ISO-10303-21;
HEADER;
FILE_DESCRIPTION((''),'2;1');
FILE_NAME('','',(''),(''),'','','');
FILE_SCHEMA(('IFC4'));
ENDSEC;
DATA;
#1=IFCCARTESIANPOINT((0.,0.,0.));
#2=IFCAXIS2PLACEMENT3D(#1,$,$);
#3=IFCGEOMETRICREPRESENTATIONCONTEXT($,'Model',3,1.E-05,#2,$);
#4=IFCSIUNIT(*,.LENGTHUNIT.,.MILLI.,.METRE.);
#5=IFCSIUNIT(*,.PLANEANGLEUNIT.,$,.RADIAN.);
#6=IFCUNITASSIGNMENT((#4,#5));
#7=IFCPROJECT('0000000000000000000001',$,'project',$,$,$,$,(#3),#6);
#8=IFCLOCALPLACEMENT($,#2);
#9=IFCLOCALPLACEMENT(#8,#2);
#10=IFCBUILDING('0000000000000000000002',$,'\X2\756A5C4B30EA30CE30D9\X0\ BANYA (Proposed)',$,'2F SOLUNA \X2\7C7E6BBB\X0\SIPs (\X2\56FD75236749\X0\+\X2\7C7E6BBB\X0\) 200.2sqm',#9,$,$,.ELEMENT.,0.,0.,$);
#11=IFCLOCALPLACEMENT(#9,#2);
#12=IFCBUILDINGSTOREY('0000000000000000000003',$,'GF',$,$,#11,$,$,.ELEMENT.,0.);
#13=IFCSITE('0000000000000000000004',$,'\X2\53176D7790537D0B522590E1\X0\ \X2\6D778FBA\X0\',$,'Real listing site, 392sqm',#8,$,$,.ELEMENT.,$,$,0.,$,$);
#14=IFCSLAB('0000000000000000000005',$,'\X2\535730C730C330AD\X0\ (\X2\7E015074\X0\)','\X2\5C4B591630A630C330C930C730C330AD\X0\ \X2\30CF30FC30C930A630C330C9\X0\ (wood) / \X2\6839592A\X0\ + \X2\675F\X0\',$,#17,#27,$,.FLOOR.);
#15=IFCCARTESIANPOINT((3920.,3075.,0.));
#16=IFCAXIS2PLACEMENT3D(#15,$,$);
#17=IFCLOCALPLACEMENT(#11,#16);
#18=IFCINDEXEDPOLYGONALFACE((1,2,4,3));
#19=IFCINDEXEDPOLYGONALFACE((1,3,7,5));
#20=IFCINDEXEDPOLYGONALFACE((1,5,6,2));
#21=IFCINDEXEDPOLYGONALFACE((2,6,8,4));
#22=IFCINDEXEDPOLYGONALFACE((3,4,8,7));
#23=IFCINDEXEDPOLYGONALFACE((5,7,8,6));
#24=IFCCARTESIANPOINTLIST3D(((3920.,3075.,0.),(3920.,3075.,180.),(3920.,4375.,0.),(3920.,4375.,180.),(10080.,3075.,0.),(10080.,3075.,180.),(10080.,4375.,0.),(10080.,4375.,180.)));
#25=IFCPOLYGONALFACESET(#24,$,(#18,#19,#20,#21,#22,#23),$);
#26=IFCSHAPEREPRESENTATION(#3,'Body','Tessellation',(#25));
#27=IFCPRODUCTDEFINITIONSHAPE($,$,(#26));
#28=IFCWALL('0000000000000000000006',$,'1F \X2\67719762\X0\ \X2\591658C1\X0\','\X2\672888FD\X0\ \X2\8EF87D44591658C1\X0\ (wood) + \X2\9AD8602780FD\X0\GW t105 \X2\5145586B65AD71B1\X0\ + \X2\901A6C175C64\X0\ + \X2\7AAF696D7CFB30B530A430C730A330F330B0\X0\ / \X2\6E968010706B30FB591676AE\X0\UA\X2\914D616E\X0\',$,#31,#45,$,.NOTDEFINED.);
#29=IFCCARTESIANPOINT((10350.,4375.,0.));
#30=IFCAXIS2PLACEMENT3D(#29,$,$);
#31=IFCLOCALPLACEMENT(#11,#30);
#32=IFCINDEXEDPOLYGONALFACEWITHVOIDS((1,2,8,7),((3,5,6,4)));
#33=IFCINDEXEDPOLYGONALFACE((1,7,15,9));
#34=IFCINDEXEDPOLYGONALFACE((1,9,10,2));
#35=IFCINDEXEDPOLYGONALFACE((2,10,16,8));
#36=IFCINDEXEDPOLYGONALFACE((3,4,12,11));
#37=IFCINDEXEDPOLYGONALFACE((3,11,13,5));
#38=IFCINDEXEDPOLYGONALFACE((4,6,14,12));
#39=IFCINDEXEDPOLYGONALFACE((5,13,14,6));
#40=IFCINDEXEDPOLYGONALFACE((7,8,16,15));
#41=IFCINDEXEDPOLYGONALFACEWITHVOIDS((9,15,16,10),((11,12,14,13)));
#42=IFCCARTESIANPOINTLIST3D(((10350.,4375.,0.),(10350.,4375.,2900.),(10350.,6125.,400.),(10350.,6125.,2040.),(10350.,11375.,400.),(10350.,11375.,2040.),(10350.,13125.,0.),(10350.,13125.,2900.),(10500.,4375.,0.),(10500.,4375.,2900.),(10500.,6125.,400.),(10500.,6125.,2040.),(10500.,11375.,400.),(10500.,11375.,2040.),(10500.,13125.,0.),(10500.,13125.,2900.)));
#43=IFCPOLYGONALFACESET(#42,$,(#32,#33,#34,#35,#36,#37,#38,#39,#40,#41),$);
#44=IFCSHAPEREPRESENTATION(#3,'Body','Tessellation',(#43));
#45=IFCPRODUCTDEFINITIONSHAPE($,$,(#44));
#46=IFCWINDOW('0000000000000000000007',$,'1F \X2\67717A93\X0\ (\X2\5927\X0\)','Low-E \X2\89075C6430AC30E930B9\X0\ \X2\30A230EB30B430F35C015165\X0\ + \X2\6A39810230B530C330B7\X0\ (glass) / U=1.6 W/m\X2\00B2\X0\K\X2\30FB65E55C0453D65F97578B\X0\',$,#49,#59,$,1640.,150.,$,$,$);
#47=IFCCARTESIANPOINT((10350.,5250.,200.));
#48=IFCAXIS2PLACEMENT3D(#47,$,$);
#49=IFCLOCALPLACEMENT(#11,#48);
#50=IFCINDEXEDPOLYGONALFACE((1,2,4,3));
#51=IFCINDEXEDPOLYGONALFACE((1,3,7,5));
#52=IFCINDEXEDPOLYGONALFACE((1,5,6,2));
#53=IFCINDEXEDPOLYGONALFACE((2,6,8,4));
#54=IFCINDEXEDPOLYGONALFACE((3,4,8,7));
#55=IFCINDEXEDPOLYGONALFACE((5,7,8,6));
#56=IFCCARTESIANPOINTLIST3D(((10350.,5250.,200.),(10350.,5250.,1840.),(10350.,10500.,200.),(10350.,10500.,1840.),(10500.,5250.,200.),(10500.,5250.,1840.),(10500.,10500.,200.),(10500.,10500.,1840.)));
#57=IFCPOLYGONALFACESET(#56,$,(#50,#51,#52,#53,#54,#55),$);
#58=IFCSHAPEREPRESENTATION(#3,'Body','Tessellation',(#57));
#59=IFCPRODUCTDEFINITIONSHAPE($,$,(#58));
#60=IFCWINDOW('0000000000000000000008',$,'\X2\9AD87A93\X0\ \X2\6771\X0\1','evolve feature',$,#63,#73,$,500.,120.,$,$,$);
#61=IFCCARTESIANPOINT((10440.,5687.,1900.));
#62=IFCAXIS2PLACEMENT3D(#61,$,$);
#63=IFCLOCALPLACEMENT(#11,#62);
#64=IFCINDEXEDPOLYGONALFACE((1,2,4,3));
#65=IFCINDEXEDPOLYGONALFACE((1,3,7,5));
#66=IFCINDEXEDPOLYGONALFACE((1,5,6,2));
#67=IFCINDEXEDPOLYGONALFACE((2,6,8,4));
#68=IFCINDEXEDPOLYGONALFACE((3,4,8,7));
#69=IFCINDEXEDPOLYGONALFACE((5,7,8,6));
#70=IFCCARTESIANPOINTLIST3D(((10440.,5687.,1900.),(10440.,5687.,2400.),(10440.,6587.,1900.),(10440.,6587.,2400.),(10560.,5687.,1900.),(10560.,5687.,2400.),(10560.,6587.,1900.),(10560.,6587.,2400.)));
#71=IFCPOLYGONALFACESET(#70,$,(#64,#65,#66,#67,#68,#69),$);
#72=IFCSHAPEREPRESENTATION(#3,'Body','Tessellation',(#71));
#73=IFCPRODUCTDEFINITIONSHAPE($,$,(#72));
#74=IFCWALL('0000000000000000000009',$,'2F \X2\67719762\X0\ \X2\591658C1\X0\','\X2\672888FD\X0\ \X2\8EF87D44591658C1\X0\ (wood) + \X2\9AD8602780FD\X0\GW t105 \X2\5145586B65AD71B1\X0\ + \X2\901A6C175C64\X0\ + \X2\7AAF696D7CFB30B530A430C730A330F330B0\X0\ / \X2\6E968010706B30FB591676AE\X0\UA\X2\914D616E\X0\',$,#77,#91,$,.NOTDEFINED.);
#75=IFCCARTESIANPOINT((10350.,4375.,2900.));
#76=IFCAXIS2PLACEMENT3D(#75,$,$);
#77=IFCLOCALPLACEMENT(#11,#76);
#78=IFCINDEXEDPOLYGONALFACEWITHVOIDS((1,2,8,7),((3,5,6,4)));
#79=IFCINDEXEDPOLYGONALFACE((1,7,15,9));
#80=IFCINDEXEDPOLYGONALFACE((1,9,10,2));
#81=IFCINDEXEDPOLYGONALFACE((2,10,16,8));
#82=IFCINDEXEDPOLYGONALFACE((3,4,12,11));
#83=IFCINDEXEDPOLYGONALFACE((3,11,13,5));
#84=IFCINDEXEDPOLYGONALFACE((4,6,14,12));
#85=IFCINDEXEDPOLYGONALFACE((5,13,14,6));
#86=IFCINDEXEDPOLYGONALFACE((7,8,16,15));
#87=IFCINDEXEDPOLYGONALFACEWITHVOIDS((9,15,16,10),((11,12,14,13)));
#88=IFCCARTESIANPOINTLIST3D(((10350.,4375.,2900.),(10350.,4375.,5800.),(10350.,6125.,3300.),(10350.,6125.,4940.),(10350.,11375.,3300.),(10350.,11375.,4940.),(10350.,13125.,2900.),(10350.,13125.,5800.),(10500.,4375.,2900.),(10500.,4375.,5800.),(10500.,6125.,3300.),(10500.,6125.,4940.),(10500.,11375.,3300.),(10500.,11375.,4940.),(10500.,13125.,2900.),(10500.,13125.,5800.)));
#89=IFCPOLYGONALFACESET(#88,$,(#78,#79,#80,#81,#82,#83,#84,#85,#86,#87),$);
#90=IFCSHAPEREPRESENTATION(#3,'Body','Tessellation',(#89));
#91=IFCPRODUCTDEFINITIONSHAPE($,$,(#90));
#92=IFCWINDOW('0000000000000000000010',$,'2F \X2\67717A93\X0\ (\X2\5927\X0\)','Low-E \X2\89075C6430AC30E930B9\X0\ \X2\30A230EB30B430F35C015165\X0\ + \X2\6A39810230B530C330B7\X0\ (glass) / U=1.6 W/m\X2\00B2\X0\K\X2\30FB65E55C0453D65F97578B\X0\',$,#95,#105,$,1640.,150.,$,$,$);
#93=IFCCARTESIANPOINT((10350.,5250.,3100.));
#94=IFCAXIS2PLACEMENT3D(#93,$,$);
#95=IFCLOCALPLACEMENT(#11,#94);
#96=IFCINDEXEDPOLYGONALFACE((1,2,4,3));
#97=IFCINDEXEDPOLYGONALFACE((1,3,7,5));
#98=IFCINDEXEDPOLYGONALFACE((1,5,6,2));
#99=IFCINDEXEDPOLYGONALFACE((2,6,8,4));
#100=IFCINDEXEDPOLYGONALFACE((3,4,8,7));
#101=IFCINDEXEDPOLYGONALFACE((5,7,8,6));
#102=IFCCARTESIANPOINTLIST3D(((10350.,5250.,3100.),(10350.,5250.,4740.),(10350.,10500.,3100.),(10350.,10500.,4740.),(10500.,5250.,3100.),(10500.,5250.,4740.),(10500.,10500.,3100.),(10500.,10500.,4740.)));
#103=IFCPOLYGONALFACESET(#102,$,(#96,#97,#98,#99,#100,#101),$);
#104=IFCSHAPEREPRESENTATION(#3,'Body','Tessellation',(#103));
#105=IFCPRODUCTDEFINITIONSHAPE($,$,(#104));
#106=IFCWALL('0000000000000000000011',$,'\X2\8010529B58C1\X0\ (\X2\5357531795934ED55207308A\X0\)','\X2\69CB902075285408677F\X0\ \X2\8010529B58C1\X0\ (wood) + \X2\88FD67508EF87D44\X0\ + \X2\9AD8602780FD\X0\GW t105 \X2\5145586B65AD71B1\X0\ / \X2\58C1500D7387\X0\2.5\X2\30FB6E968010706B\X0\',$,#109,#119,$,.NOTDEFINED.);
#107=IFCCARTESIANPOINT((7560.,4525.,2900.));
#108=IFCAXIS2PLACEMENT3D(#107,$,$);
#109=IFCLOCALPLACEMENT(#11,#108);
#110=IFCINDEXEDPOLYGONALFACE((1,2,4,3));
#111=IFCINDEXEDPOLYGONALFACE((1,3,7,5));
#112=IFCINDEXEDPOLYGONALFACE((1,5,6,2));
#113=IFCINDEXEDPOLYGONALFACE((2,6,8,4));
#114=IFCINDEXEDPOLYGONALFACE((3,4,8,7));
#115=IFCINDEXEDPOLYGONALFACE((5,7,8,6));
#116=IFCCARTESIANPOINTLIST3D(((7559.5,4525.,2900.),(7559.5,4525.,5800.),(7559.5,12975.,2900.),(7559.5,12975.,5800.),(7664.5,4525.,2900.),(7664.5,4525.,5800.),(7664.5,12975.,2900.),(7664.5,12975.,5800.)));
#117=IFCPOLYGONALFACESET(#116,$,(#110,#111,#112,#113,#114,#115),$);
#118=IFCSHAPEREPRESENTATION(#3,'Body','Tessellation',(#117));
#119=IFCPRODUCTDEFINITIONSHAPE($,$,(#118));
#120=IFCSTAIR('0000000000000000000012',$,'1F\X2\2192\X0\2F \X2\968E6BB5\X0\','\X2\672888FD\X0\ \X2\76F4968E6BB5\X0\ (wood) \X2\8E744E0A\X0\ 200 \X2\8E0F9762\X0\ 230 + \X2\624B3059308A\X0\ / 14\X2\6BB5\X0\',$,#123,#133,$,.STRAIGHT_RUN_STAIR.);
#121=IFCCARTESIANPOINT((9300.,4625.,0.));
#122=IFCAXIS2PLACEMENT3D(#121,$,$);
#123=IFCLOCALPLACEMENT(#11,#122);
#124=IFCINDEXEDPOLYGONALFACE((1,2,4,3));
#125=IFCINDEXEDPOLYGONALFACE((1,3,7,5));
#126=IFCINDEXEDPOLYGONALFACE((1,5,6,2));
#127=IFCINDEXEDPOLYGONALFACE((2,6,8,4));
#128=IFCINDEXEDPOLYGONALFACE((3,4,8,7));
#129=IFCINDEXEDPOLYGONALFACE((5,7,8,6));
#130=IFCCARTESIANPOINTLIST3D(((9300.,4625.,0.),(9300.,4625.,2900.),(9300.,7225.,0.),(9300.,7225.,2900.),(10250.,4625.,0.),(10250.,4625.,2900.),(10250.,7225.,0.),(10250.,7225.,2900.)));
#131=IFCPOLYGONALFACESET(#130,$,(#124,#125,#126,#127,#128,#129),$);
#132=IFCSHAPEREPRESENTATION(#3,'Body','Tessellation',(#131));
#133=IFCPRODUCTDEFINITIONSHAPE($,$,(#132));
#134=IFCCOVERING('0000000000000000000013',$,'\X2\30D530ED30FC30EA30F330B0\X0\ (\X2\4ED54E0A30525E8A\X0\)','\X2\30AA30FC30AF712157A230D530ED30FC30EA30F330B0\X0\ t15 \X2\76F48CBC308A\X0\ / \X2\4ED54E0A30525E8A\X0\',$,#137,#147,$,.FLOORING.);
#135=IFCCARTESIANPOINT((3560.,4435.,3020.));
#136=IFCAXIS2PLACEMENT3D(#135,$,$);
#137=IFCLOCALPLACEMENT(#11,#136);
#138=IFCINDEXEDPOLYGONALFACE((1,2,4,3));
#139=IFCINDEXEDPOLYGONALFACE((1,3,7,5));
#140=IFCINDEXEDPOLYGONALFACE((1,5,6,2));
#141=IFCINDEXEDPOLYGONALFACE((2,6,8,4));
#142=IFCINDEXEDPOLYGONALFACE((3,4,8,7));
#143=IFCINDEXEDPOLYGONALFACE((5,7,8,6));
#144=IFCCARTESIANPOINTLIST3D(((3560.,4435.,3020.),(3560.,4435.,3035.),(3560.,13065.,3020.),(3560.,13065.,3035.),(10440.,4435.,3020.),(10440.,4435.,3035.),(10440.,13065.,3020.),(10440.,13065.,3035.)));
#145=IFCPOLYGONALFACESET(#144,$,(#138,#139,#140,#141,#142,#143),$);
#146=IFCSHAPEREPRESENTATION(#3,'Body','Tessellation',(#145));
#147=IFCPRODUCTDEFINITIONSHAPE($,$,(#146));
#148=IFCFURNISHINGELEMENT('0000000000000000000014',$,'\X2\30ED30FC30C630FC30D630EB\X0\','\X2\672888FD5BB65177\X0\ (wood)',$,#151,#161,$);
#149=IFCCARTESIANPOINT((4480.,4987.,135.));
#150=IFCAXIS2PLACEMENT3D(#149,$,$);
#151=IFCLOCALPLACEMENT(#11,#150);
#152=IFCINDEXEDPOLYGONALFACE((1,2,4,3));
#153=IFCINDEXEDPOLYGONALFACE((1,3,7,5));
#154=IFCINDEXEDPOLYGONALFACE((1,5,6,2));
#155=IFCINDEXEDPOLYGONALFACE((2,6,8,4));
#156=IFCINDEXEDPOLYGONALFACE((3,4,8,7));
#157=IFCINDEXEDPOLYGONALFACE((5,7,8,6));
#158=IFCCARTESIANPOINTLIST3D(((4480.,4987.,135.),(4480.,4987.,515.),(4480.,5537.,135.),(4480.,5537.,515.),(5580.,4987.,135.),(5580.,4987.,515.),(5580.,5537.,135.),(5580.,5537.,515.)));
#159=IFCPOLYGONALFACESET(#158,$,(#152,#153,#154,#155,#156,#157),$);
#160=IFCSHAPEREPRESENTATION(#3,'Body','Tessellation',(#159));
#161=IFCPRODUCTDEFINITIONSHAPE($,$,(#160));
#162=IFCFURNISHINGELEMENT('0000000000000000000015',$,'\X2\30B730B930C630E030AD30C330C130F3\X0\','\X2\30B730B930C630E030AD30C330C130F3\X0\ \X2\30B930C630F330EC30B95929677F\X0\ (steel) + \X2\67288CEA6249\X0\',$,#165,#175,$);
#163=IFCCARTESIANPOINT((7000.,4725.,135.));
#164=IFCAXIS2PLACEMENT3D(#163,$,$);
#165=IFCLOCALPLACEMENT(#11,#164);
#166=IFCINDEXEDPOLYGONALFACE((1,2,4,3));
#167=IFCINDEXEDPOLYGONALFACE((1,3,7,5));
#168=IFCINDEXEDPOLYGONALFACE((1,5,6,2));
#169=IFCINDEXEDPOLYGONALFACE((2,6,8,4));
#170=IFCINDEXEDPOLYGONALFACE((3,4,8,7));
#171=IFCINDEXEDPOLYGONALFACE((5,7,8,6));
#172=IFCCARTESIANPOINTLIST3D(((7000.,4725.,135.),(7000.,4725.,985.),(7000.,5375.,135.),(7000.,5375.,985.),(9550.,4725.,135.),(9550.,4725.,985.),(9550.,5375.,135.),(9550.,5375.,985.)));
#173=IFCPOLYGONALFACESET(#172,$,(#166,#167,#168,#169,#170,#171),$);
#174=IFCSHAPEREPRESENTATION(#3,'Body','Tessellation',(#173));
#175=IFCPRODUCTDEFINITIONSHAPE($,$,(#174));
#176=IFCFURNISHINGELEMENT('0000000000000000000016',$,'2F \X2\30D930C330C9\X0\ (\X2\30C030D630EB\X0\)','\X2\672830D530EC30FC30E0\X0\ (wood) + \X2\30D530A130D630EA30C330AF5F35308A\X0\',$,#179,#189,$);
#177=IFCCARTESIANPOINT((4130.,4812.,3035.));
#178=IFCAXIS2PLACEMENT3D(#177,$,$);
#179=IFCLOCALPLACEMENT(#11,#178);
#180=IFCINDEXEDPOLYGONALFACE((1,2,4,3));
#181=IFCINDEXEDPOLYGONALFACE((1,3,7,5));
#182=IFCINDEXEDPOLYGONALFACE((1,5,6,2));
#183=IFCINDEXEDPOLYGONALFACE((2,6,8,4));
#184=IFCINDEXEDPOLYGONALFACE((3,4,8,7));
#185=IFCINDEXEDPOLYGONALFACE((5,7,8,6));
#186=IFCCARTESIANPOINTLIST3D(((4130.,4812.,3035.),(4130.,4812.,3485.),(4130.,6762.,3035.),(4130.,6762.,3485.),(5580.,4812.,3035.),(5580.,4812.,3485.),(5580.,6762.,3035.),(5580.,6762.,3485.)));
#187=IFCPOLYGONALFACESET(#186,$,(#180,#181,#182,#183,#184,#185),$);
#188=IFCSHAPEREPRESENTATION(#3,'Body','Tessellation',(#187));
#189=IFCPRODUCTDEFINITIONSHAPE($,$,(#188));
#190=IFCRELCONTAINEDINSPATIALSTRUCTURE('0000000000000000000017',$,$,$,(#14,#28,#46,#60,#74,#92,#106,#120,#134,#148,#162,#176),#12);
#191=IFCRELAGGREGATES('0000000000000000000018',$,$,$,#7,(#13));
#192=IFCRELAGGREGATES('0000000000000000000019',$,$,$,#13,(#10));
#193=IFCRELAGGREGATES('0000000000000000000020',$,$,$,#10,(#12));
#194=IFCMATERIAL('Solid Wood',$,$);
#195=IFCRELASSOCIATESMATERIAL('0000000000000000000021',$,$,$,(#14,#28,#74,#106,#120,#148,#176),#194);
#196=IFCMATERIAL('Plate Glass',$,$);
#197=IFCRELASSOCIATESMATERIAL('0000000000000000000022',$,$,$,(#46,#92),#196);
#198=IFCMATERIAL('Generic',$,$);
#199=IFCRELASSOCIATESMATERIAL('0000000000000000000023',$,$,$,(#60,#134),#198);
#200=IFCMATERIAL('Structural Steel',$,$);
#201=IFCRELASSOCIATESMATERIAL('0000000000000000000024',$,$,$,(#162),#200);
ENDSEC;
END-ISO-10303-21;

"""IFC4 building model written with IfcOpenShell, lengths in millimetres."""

from ifc_helpers import new_model, si_unit, frame, frame_2d, origin, place, context, project, spatial, rectangle, extrude, material, element, fill, save


model = new_model("IFC4")

# Units and contexts
model_context = context("Model", 3, precision=1e-05, world=origin())
ifc_project = project(units=[si_unit("LENGTHUNIT", "METRE", prefix="MILLI"), si_unit("PLANEANGLEUNIT", "RADIAN")], contexts=[model_context])

# Site, building, storey
site_placement = place(None, origin())
site = spatial("IfcSite", under=ifc_project, at=site_placement, Name="北海道紋別郡 海辺", ObjectType="Real listing site, 392sqm", CompositionType="ELEMENT", RefElevation=0.0)
building_placement = place(site_placement, origin())
building = spatial("IfcBuilding", under=site, at=building_placement, Name="番屋リノベ BANYA (Proposed)", ObjectType="2F SOLUNA 籾殻SIPs (国産杉+籾殻) 200.2sqm", CompositionType="ELEMENT", ElevationOfRefHeight=0.0, ElevationOfTerrain=0.0)
storey_placement = place(building_placement, origin())
storey = spatial("IfcBuildingStorey", under=building, at=storey_placement, Name="GF", CompositionType="ELEMENT", Elevation=0.0)

# Slab
ifc_material_1 = material(Name="Solid Wood")
slab_placement = place(storey_placement, frame((3920.0, 3075.0, 0.0)))
element("IfcSlab", 1, at=slab_placement, inside=storey, material=ifc_material_1, Name="南デッキ (縁側)", Description="屋外ウッドデッキ ハードウッド (wood) / 根太 + 束", PredefinedType="FLOOR", context=model_context, shape_type="SweptSolid", body=[
    extrude(rectangle(XDim=6160.0, YDim=1300.0, at=frame_2d((3080.0, 650.0))), frame((3920.0, 3075.0, 0.0)), (0.0, 0.0, 1.0), 180.0),
])

# Wall, openings, windows
wall_1_placement = place(storey_placement, frame((10350.0, 4375.0, 0.0)))
wall_1 = element("IfcWall", 2, at=wall_1_placement, inside=storey, material=ifc_material_1, Name="1F 東面 外壁", Description="木製 軸組外壁 (wood) + 高性能GW t105 充填断熱 + 通気層 + 窯業系サイディング / 準耐火・外皮UA配慮", PredefinedType="NOTDEFINED", context=model_context, shape_type="SweptSolid", body=[
    extrude(rectangle(XDim=150.0, YDim=8750.0, at=frame_2d((75.0, 4375.0))), frame((10350.0, 4375.0, 0.0)), (0.0, 0.0, 1.0), 2900.0),
])
opening_1_placement = place(storey_placement, frame((10350.0, 5250.0, 200.0)))
opening_1 = element("IfcOpeningElement", 3, at=opening_1_placement, cuts=wall_1, PredefinedType="NOTDEFINED", context=model_context, shape_type="SweptSolid", body=[
    extrude(rectangle(XDim=150.0, YDim=5250.0, at=frame_2d((75.0, 2625.0))), frame((10350.0, 5250.0, 200.0)), (0.0, 0.0, 1.0), 1640.0),
])
opening_2_placement = place(storey_placement, frame((10440.0, 5687.0, 1900.0)))
opening_2 = element("IfcOpeningElement", 4, at=opening_2_placement, cuts=wall_1, PredefinedType="NOTDEFINED", context=model_context, shape_type="SweptSolid", body=[
    extrude(rectangle(XDim=120.0, YDim=900.0, at=frame_2d((60.0, 450.0))), frame((10440.0, 5687.0, 1900.0)), (0.0, 0.0, 1.0), 500.0),
])
ifc_material_2 = material(Name="Plate Glass")
window_1_placement = place(storey_placement, frame((10350.0, 5250.0, 200.0)))
window_1 = element("IfcWindow", 5, at=window_1_placement, inside=storey, material=ifc_material_2, Name="1F 東窓 (大)", Description="Low-E 複層ガラス アルゴン封入 + 樹脂サッシ (glass) / U=1.6 W/m²K・日射取得型", OverallHeight=1640.0, OverallWidth=150.0, context=model_context, shape_type="SweptSolid", body=[
    extrude(rectangle(XDim=150.0, YDim=5250.0, at=frame_2d((75.0, 2625.0))), frame((10350.0, 5250.0, 200.0)), (0.0, 0.0, 1.0), 1640.0),
])
fill(opening_1, window_1)
ifc_material_3 = material(Name="Generic")
window_2_placement = place(storey_placement, frame((10440.0, 5687.0, 1900.0)))
window_2 = element("IfcWindow", 6, at=window_2_placement, inside=storey, material=ifc_material_3, Name="高窓 東1", Description="evolve feature", OverallHeight=500.0, OverallWidth=120.0, context=model_context, shape_type="SweptSolid", body=[
    extrude(rectangle(XDim=120.0, YDim=900.0, at=frame_2d((60.0, 450.0))), frame((10440.0, 5687.0, 1900.0)), (0.0, 0.0, 1.0), 500.0),
])
fill(opening_2, window_2)

# Wall, opening, window
wall_2_placement = place(storey_placement, frame((10350.0, 4375.0, 2900.0)))
wall_2 = element("IfcWall", 7, at=wall_2_placement, inside=storey, material=ifc_material_1, Name="2F 東面 外壁", Description="木製 軸組外壁 (wood) + 高性能GW t105 充填断熱 + 通気層 + 窯業系サイディング / 準耐火・外皮UA配慮", PredefinedType="NOTDEFINED", context=model_context, shape_type="SweptSolid", body=[
    extrude(rectangle(XDim=150.0, YDim=8750.0, at=frame_2d((75.0, 4375.0))), frame((10350.0, 4375.0, 2900.0)), (0.0, 0.0, 1.0), 2900.0),
])
opening_3_placement = place(storey_placement, frame((10350.0, 5250.0, 3100.0)))
opening_3 = element("IfcOpeningElement", 8, at=opening_3_placement, cuts=wall_2, PredefinedType="NOTDEFINED", context=model_context, shape_type="SweptSolid", body=[
    extrude(rectangle(XDim=150.0, YDim=5250.0, at=frame_2d((75.0, 2625.0))), frame((10350.0, 5250.0, 3100.0)), (0.0, 0.0, 1.0), 1640.0),
])
window_3_placement = place(storey_placement, frame((10350.0, 5250.0, 3100.0)))
window_3 = element("IfcWindow", 9, at=window_3_placement, inside=storey, material=ifc_material_2, Name="2F 東窓 (大)", Description="Low-E 複層ガラス アルゴン封入 + 樹脂サッシ (glass) / U=1.6 W/m²K・日射取得型", OverallHeight=1640.0, OverallWidth=150.0, context=model_context, shape_type="SweptSolid", body=[
    extrude(rectangle(XDim=150.0, YDim=5250.0, at=frame_2d((75.0, 2625.0))), frame((10350.0, 5250.0, 3100.0)), (0.0, 0.0, 1.0), 1640.0),
])
fill(opening_3, window_3)

# Wall
wall_3_placement = place(storey_placement, frame((7560.0, 4525.0, 2900.0)))
element("IfcWall", 10, at=wall_3_placement, inside=storey, material=ifc_material_1, Name="耐力壁 (南北間仕切り)", Description="構造用合板 耐力壁 (wood) + 製材軸組 + 高性能GW t105 充填断熱 / 壁倍率2.5・準耐火", PredefinedType="NOTDEFINED", context=model_context, shape_type="SweptSolid", body=[
    extrude(rectangle(XDim=105.0, YDim=8450.0, at=frame_2d((52.0, 4225.0))), frame((7560.0, 4525.0, 2900.0)), (0.0, 0.0, 1.0), 2900.0),
])

# Stair
stair_placement = place(storey_placement, frame((9300.0, 4625.0, 0.0)))
element("IfcStair", 11, at=stair_placement, inside=storey, material=ifc_material_1, Name="1F→2F 階段", Description="木製 直階段 (wood) 蹴上 200 踏面 230 + 手すり / 14段", PredefinedType="STRAIGHT_RUN_STAIR", context=model_context, shape_type="SweptSolid", body=[
    extrude(rectangle(XDim=950.0, YDim=2600.0, at=frame_2d((475.0, 1300.0))), frame((9300.0, 4625.0, 0.0)), (0.0, 0.0, 1.0), 2900.0),
])

# Covering
covering_placement = place(storey_placement, frame((3560.0, 4435.0, 3020.0)))
element("IfcCovering", 12, at=covering_placement, inside=storey, material=ifc_material_3, Name="フローリング (仕上げ床)", Description="オーク無垢フローリング t15 直貼り / 仕上げ床", PredefinedType="FLOORING", context=model_context, shape_type="SweptSolid", body=[
    extrude(rectangle(XDim=6880.0, YDim=8630.0, at=frame_2d((3440.0, 4315.0))), frame((3560.0, 4435.0, 3020.0)), (0.0, 0.0, 1.0), 15.0),
])

# Furnishing elements
furnishing_1_placement = place(storey_placement, frame((4480.0, 4987.0, 135.0)))
element("IfcFurnishingElement", 13, at=furnishing_1_placement, inside=storey, material=ifc_material_1, Name="ローテーブル", Description="木製家具 (wood)", context=model_context, shape_type="SweptSolid", body=[
    extrude(rectangle(XDim=1100.0, YDim=550.0, at=frame_2d((550.0, 275.0))), frame((4480.0, 4987.0, 135.0)), (0.0, 0.0, 1.0), 380.0),
])
ifc_material_4 = material(Name="Structural Steel")
furnishing_2_placement = place(storey_placement, frame((7000.0, 4725.0, 135.0)))
element("IfcFurnishingElement", 14, at=furnishing_2_placement, inside=storey, material=ifc_material_4, Name="システムキッチン", Description="システムキッチン ステンレス天板 (steel) + 木質扉", context=model_context, shape_type="SweptSolid", body=[
    extrude(rectangle(XDim=2550.0, YDim=650.0, at=frame_2d((1275.0, 325.0))), frame((7000.0, 4725.0, 135.0)), (0.0, 0.0, 1.0), 850.0),
])
furnishing_3_placement = place(storey_placement, frame((4130.0, 4812.0, 3035.0)))
element("IfcFurnishingElement", 15, at=furnishing_3_placement, inside=storey, material=ifc_material_1, Name="2F ベッド (ダブル)", Description="木フレーム (wood) + ファブリック張り", context=model_context, shape_type="SweptSolid", body=[
    extrude(rectangle(XDim=1450.0, YDim=1950.0, at=frame_2d((725.0, 975.0))), frame((4130.0, 4812.0, 3035.0)), (0.0, 0.0, 1.0), 450.0),
])

save(model, "model.ifc")
